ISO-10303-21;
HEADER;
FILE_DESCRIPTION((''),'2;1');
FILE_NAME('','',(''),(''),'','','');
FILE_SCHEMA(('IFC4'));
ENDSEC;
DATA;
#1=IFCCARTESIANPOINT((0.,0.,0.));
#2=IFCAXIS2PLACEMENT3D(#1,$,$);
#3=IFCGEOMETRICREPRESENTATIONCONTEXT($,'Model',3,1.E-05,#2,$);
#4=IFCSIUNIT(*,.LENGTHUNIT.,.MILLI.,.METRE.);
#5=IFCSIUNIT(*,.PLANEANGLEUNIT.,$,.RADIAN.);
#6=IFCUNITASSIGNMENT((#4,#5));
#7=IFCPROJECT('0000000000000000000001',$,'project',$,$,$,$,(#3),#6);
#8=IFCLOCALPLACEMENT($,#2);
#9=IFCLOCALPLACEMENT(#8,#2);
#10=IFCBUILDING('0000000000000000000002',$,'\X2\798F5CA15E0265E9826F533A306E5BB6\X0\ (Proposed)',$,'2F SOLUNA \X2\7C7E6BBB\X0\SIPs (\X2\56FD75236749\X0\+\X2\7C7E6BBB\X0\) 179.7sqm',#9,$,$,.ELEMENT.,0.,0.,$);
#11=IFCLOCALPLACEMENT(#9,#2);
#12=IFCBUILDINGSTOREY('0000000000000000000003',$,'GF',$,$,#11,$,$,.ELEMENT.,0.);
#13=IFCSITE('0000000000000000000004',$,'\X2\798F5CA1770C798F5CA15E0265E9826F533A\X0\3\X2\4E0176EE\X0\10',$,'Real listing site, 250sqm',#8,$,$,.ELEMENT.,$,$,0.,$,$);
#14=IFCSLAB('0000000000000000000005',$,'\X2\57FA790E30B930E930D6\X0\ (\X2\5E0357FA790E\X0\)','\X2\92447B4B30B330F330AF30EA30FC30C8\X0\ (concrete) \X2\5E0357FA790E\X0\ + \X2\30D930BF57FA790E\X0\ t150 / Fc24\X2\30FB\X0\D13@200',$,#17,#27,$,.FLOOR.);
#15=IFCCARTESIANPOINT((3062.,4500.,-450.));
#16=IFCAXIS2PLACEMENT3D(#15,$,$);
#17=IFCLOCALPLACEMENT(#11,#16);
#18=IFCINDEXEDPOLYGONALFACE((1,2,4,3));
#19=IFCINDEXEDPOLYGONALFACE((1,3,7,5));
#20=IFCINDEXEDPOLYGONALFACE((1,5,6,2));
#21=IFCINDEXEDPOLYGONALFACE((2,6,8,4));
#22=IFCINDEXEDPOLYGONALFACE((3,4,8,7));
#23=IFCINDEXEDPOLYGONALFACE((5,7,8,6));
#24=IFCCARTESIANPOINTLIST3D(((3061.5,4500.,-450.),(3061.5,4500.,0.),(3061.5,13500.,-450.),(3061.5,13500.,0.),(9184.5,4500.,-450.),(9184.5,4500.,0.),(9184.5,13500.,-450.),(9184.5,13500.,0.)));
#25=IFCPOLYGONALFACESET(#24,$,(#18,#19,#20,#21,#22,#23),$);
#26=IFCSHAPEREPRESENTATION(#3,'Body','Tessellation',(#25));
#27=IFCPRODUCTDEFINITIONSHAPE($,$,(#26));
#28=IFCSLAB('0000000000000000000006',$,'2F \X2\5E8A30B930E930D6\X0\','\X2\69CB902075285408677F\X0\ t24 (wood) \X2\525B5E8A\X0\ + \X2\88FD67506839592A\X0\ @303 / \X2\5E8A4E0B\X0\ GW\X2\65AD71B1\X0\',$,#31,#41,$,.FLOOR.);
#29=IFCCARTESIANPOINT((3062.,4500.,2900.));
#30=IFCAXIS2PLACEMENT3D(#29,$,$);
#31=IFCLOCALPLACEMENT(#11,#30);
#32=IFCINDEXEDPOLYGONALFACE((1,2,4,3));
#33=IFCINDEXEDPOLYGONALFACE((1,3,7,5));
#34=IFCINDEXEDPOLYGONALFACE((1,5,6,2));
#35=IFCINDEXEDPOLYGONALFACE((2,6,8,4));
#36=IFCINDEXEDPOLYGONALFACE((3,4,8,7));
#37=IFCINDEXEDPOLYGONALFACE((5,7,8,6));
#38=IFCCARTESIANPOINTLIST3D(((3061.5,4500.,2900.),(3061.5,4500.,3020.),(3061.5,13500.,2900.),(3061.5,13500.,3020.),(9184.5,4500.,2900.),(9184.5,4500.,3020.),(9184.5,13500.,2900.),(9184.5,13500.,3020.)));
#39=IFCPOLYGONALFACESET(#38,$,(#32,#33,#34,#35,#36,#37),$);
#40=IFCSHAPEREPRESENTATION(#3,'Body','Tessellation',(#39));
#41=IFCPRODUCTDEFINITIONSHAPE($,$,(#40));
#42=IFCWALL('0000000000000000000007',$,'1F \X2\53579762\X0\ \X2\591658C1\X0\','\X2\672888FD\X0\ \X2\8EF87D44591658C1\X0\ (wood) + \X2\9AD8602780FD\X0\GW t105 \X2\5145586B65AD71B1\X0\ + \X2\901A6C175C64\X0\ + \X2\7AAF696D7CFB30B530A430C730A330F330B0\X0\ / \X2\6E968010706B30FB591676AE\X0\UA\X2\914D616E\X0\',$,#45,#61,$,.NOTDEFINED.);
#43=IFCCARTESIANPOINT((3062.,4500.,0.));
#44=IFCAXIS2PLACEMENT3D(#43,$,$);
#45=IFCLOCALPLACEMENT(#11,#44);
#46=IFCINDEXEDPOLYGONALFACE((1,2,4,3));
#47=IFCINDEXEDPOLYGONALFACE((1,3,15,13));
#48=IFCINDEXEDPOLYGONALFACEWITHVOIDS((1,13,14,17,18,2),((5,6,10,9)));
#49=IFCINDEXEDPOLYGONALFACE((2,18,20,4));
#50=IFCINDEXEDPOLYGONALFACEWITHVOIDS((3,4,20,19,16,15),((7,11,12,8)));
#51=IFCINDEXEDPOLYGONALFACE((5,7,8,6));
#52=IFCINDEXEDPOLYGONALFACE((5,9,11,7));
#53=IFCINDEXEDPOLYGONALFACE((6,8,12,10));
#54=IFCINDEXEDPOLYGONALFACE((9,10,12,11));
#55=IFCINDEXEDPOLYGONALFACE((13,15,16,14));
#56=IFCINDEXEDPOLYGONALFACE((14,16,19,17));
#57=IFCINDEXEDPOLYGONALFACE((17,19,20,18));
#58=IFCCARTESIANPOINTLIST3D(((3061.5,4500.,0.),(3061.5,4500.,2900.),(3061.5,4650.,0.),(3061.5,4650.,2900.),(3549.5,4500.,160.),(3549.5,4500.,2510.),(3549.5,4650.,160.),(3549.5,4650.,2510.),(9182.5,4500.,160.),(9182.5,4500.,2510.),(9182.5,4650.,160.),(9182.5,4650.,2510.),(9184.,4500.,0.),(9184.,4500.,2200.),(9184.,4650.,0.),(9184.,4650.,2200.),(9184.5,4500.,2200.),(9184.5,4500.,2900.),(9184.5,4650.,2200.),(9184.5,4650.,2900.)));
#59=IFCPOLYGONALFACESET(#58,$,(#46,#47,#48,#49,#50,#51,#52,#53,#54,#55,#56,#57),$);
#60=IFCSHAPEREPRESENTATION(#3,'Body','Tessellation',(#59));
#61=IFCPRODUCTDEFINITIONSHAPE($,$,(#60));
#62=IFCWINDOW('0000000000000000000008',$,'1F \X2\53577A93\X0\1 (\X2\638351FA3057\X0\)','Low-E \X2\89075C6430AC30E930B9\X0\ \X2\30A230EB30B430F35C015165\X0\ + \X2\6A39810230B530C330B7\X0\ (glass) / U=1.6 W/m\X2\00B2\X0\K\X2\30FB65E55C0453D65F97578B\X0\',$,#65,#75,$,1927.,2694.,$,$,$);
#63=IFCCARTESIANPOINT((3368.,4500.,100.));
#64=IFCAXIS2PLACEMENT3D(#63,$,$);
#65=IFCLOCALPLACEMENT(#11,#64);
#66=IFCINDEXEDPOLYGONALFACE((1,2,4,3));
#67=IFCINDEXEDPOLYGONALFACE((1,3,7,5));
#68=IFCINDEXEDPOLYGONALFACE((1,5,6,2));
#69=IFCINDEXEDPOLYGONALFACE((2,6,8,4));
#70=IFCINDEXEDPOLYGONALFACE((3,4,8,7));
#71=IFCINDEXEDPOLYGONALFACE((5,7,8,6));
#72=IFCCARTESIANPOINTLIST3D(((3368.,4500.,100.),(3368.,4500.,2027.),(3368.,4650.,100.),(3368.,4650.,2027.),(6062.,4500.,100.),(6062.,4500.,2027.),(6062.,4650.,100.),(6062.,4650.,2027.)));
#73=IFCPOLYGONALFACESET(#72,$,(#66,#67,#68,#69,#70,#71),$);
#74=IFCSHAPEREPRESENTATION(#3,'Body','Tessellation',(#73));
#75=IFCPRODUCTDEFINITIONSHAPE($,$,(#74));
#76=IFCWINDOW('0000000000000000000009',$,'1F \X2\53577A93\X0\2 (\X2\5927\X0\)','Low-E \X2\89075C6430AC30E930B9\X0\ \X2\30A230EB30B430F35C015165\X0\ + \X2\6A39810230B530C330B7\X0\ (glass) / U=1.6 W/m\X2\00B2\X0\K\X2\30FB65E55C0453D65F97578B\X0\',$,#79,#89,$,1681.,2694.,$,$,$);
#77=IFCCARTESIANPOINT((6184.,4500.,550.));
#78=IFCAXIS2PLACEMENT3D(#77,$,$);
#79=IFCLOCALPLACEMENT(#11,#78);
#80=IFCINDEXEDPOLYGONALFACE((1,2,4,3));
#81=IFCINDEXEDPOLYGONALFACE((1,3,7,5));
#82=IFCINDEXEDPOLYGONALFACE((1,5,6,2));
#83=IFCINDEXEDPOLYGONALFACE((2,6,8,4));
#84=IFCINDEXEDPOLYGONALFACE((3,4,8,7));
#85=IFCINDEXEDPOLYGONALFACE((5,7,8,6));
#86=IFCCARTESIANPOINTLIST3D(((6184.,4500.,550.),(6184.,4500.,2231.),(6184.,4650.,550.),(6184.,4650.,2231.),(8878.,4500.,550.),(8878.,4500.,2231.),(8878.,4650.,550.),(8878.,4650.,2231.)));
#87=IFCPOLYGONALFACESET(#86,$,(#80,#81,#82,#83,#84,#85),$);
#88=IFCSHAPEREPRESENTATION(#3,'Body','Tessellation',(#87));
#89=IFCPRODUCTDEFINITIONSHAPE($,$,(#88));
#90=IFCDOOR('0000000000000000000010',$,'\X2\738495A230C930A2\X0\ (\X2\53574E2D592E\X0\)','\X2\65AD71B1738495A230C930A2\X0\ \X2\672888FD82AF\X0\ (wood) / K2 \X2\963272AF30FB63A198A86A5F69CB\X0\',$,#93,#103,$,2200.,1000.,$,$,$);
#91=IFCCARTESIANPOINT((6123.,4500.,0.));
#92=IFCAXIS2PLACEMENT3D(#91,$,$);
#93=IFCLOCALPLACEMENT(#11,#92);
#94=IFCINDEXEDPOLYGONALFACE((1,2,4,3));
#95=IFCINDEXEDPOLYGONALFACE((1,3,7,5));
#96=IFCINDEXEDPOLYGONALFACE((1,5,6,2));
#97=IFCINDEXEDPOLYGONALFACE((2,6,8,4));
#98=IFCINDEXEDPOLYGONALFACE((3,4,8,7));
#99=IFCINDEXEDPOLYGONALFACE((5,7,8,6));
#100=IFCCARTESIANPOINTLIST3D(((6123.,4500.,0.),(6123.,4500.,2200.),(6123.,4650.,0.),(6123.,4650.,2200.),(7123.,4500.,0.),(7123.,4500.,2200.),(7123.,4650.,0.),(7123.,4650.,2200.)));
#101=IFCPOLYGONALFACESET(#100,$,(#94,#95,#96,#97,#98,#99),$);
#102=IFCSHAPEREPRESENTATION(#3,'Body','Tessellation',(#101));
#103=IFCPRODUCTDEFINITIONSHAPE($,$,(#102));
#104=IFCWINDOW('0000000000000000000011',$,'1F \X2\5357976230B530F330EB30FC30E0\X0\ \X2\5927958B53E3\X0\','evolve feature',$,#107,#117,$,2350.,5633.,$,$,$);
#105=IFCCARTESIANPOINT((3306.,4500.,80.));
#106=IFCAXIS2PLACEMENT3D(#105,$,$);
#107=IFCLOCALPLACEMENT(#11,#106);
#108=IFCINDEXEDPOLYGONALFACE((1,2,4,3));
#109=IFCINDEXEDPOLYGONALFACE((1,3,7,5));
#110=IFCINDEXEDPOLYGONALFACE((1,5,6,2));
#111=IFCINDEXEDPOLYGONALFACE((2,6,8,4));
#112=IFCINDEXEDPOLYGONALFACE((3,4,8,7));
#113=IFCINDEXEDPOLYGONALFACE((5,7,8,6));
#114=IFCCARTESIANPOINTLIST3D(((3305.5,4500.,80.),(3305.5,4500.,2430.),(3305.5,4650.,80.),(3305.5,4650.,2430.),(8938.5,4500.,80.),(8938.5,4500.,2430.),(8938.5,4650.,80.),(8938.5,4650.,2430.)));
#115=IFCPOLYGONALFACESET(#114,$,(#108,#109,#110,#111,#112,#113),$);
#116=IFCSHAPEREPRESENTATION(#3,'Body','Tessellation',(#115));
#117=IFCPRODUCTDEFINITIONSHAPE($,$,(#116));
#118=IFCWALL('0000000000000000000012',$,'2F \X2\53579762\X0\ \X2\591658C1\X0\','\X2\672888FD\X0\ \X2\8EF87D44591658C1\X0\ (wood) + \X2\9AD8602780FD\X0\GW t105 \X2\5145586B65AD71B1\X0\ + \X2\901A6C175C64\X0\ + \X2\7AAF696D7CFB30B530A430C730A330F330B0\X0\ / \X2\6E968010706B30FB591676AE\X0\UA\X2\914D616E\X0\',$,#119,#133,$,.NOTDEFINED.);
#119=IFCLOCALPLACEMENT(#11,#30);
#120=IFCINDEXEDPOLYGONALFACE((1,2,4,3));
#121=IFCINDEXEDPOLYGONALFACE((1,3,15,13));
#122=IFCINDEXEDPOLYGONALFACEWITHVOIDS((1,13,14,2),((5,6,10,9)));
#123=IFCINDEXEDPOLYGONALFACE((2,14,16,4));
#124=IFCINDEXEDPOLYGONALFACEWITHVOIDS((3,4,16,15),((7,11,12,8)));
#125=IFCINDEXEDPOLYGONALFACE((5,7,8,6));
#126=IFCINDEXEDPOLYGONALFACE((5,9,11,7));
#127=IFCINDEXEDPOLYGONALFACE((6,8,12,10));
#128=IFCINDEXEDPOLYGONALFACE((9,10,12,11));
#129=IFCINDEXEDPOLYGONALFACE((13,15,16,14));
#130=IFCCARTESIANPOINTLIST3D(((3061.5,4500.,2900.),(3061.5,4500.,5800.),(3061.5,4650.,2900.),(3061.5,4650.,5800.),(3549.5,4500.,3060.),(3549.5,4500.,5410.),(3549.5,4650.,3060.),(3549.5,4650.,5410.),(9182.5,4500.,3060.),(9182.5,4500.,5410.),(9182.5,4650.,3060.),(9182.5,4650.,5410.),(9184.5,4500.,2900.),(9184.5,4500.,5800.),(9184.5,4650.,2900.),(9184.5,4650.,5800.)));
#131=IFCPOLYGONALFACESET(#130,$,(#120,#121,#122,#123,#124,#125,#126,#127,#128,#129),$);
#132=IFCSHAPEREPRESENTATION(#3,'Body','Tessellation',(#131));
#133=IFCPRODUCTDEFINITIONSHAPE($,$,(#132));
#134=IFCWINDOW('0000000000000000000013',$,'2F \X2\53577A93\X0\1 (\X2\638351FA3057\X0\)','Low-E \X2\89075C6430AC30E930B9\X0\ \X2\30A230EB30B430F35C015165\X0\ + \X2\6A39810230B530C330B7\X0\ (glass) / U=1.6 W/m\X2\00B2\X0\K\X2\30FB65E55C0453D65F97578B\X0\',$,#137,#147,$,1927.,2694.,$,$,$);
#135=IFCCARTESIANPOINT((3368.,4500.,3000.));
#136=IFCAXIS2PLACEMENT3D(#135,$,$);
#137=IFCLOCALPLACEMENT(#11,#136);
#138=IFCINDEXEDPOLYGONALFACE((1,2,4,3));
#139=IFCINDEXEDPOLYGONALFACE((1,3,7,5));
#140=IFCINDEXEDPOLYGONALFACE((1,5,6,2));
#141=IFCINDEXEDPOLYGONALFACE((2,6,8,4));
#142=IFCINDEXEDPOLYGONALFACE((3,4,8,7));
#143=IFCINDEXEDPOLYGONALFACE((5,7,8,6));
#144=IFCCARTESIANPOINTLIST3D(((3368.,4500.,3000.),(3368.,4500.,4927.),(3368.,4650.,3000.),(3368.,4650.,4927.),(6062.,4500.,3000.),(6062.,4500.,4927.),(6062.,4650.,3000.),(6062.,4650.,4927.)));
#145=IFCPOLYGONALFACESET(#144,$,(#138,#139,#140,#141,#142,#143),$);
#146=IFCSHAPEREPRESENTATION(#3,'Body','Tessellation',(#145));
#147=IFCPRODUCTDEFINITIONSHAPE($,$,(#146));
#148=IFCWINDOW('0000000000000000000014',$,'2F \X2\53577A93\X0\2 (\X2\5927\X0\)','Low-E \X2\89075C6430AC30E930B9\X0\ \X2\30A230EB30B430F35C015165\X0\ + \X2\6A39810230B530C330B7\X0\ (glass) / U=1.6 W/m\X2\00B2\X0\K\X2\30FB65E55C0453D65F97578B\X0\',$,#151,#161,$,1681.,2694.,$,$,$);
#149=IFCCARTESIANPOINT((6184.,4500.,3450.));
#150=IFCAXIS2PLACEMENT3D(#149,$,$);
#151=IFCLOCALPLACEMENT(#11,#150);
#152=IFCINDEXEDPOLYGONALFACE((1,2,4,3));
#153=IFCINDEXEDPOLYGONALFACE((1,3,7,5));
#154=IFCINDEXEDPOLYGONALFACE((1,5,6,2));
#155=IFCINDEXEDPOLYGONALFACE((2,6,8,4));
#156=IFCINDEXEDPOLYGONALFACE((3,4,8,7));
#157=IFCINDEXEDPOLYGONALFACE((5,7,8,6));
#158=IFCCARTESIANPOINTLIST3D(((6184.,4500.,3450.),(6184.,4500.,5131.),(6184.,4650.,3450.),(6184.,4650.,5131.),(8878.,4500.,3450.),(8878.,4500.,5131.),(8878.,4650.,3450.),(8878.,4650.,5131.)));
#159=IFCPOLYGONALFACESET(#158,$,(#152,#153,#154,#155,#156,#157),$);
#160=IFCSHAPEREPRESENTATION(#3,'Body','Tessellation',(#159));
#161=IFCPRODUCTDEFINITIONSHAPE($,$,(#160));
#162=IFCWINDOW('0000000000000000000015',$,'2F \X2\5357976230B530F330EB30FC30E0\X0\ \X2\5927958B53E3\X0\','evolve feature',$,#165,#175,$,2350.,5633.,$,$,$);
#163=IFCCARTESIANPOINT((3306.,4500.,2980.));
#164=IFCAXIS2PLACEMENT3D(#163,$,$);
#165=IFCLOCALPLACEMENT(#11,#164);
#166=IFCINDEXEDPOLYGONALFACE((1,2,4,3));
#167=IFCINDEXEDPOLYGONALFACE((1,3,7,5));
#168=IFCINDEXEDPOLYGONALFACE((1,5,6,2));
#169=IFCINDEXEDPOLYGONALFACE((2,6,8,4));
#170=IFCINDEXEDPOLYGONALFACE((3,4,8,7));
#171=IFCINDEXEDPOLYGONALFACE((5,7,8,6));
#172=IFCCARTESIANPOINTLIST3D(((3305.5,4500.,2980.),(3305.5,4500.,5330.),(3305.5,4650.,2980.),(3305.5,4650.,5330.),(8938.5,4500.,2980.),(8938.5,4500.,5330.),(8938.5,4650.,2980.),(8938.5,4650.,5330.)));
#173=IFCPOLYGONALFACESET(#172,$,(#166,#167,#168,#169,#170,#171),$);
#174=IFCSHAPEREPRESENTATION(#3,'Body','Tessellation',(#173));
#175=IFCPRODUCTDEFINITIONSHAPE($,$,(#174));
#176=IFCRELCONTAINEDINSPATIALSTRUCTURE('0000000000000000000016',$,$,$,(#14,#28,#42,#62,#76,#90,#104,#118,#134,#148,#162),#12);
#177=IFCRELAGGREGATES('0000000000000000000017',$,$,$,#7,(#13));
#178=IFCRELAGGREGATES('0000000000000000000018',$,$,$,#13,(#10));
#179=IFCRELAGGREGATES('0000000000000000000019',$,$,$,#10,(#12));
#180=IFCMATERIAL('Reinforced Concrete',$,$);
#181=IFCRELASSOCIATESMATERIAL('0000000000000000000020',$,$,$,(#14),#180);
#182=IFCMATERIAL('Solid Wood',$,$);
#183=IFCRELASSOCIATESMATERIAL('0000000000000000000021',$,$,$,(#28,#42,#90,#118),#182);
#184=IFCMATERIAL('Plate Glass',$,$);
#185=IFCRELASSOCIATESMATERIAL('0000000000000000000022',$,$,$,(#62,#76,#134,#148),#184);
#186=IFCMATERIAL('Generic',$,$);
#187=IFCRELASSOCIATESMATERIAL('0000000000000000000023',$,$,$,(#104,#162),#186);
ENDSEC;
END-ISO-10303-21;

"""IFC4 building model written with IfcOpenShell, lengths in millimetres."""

from ifc_helpers import new_model, si_unit, frame, frame_2d, origin, place, context, project, spatial, rectangle, extrude, material, element, fill, save


model = new_model("IFC4")

# Units and contexts
model_context = context("Model", 3, precision=1e-05, world=origin())
ifc_project = project(units=[si_unit("LENGTHUNIT", "METRE", prefix="MILLI"), si_unit("PLANEANGLEUNIT", "RADIAN")], contexts=[model_context])

# Site, building, storey
site_placement = place(None, origin())
site = spatial("IfcSite", under=ifc_project, at=site_placement, Name="福岡県福岡市早良区3丁目10", ObjectType="Real listing site, 250sqm", CompositionType="ELEMENT", RefElevation=0.0)
building_placement = place(site_placement, origin())
building = spatial("IfcBuilding", under=site, at=building_placement, Name="福岡市早良区の家 (Proposed)", ObjectType="2F SOLUNA 籾殻SIPs (国産杉+籾殻) 179.7sqm", CompositionType="ELEMENT", ElevationOfRefHeight=0.0, ElevationOfTerrain=0.0)
storey_placement = place(building_placement, origin())
storey = spatial("IfcBuildingStorey", under=building, at=storey_placement, Name="GF", CompositionType="ELEMENT", Elevation=0.0)

# Slabs
ifc_material_1 = material(Name="Reinforced Concrete")
slab_1_placement = place(storey_placement, frame((3062.0, 4500.0, -450.0)))
element("IfcSlab", 1, at=slab_1_placement, inside=storey, material=ifc_material_1, Name="基礎スラブ (布基礎)", Description="鉄筋コンクリート (concrete) 布基礎 + ベタ基礎 t150 / Fc24・D13@200", PredefinedType="FLOOR", context=model_context, shape_type="SweptSolid", body=[
    extrude(rectangle(XDim=6123.0, YDim=9000.0, at=frame_2d((3061.0, 4500.0))), frame((3062.0, 4500.0, -450.0)), (0.0, 0.0, 1.0), 450.0),
])
ifc_material_2 = material(Name="Solid Wood")
slab_2_placement = place(storey_placement, frame((3062.0, 4500.0, 2900.0)))
element("IfcSlab", 2, at=slab_2_placement, inside=storey, material=ifc_material_2, Name="2F 床スラブ", Description="構造用合板 t24 (wood) 剛床 + 製材根太 @303 / 床下 GW断熱", PredefinedType="FLOOR", context=model_context, shape_type="SweptSolid", body=[
    extrude(rectangle(XDim=6123.0, YDim=9000.0, at=frame_2d((3061.0, 4500.0))), frame((3062.0, 4500.0, 2900.0)), (0.0, 0.0, 1.0), 120.0),
])
ifc_material_3 = material(Name="Generic")

# Wall, openings, windows, door
wall_1_placement = place(storey_placement, frame((3062.0, 4500.0, 0.0)))
wall_1 = element("IfcWall", 3, at=wall_1_placement, inside=storey, material=ifc_material_2, Name="1F 南面 外壁", Description="木製 軸組外壁 (wood) + 高性能GW t105 充填断熱 + 通気層 + 窯業系サイディング / 準耐火・外皮UA配慮", PredefinedType="NOTDEFINED", context=model_context, shape_type="SweptSolid", body=[
    extrude(rectangle(XDim=6123.0, YDim=150.0, at=frame_2d((3061.0, 75.0))), frame((3062.0, 4500.0, 0.0)), (0.0, 0.0, 1.0), 2900.0),
])
opening_1_placement = place(storey_placement, frame((3368.0, 4500.0, 100.0)))
opening_1 = element("IfcOpeningElement", 4, at=opening_1_placement, cuts=wall_1, PredefinedType="NOTDEFINED", context=model_context, shape_type="SweptSolid", body=[
    extrude(rectangle(XDim=2694.0, YDim=150.0, at=frame_2d((1347.0, 75.0))), frame((3368.0, 4500.0, 100.0)), (0.0, 0.0, 1.0), 1927.0),
])
opening_2_placement = place(storey_placement, frame((6184.0, 4500.0, 550.0)))
opening_2 = element("IfcOpeningElement", 5, at=opening_2_placement, cuts=wall_1, PredefinedType="NOTDEFINED", context=model_context, shape_type="SweptSolid", body=[
    extrude(rectangle(XDim=2694.0, YDim=150.0, at=frame_2d((1347.0, 75.0))), frame((6184.0, 4500.0, 550.0)), (0.0, 0.0, 1.0), 1681.0),
])
opening_3_placement = place(storey_placement, frame((6123.0, 4500.0, 0.0)))
opening_3 = element("IfcOpeningElement", 6, at=opening_3_placement, cuts=wall_1, PredefinedType="NOTDEFINED", context=model_context, shape_type="SweptSolid", body=[
    extrude(rectangle(XDim=1000.0, YDim=150.0, at=frame_2d((500.0, 75.0))), frame((6123.0, 4500.0, 0.0)), (0.0, 0.0, 1.0), 2200.0),
])
opening_4_placement = place(storey_placement, frame((3306.0, 4500.0, 80.0)))
opening_4 = element("IfcOpeningElement", 7, at=opening_4_placement, cuts=wall_1, PredefinedType="NOTDEFINED", context=model_context, shape_type="SweptSolid", body=[
    extrude(rectangle(XDim=5633.0, YDim=150.0, at=frame_2d((2816.0, 75.0))), frame((3306.0, 4500.0, 80.0)), (0.0, 0.0, 1.0), 2350.0),
])
ifc_material_4 = material(Name="Plate Glass")
window_1_placement = place(storey_placement, frame((3368.0, 4500.0, 100.0)))
window_1 = element("IfcWindow", 8, at=window_1_placement, inside=storey, material=ifc_material_4, Name="1F 南窓1 (掃出し)", Description="Low-E 複層ガラス アルゴン封入 + 樹脂サッシ (glass) / U=1.6 W/m²K・日射取得型", OverallHeight=1927.0, OverallWidth=2694.0, context=model_context, shape_type="SweptSolid", body=[
    extrude(rectangle(XDim=2694.0, YDim=150.0, at=frame_2d((1347.0, 75.0))), frame((3368.0, 4500.0, 100.0)), (0.0, 0.0, 1.0), 1927.0),
])
fill(opening_1, window_1)
window_2_placement = place(storey_placement, frame((6184.0, 4500.0, 550.0)))
window_2 = element("IfcWindow", 9, at=window_2_placement, inside=storey, material=ifc_material_4, Name="1F 南窓2 (大)", Description="Low-E 複層ガラス アルゴン封入 + 樹脂サッシ (glass) / U=1.6 W/m²K・日射取得型", OverallHeight=1681.0, OverallWidth=2694.0, context=model_context, shape_type="SweptSolid", body=[
    extrude(rectangle(XDim=2694.0, YDim=150.0, at=frame_2d((1347.0, 75.0))), frame((6184.0, 4500.0, 550.0)), (0.0, 0.0, 1.0), 1681.0),
])
fill(opening_2, window_2)
door_placement = place(storey_placement, frame((6123.0, 4500.0, 0.0)))
door = element("IfcDoor", 10, at=door_placement, inside=storey, material=ifc_material_2, Name="玄関ドア (南中央)", Description="断熱玄関ドア 木製芯 (wood) / K2 防犯・採風機構", OverallHeight=2200.0, OverallWidth=1000.0, context=model_context, shape_type="SweptSolid", body=[
    extrude(rectangle(XDim=1000.0, YDim=150.0, at=frame_2d((500.0, 75.0))), frame((6123.0, 4500.0, 0.0)), (0.0, 0.0, 1.0), 2200.0),
])
fill(opening_3, door)
window_3_placement = place(storey_placement, frame((3306.0, 4500.0, 80.0)))
window_3 = element("IfcWindow", 11, at=window_3_placement, inside=storey, material=ifc_material_3, Name="1F 南面サンルーム 大開口", Description="evolve feature", OverallHeight=2350.0, OverallWidth=5633.0, context=model_context, shape_type="SweptSolid", body=[
    extrude(rectangle(XDim=5633.0, YDim=150.0, at=frame_2d((2816.0, 75.0))), frame((3306.0, 4500.0, 80.0)), (0.0, 0.0, 1.0), 2350.0),
])
fill(opening_4, window_3)

# Wall, openings, windows
wall_2_placement = place(storey_placement, frame((3062.0, 4500.0, 2900.0)))
wall_2 = element("IfcWall", 12, at=wall_2_placement, inside=storey, material=ifc_material_2, Name="2F 南面 外壁", Description="木製 軸組外壁 (wood) + 高性能GW t105 充填断熱 + 通気層 + 窯業系サイディング / 準耐火・外皮UA配慮", PredefinedType="NOTDEFINED", context=model_context, shape_type="SweptSolid", body=[
    extrude(rectangle(XDim=6123.0, YDim=150.0, at=frame_2d((3061.0, 75.0))), frame((3062.0, 4500.0, 2900.0)), (0.0, 0.0, 1.0), 2900.0),
])
opening_5_placement = place(storey_placement, frame((3368.0, 4500.0, 3000.0)))
opening_5 = element("IfcOpeningElement", 13, at=opening_5_placement, cuts=wall_2, PredefinedType="NOTDEFINED", context=model_context, shape_type="SweptSolid", body=[
    extrude(rectangle(XDim=2694.0, YDim=150.0, at=frame_2d((1347.0, 75.0))), frame((3368.0, 4500.0, 3000.0)), (0.0, 0.0, 1.0), 1927.0),
])
opening_6_placement = place(storey_placement, frame((6184.0, 4500.0, 3450.0)))
opening_6 = element("IfcOpeningElement", 14, at=opening_6_placement, cuts=wall_2, PredefinedType="NOTDEFINED", context=model_context, shape_type="SweptSolid", body=[
    extrude(rectangle(XDim=2694.0, YDim=150.0, at=frame_2d((1347.0, 75.0))), frame((6184.0, 4500.0, 3450.0)), (0.0, 0.0, 1.0), 1681.0),
])
opening_7_placement = place(storey_placement, frame((3306.0, 4500.0, 2980.0)))
opening_7 = element("IfcOpeningElement", 15, at=opening_7_placement, cuts=wall_2, PredefinedType="NOTDEFINED", context=model_context, shape_type="SweptSolid", body=[
    extrude(rectangle(XDim=5633.0, YDim=150.0, at=frame_2d((2816.0, 75.0))), frame((3306.0, 4500.0, 2980.0)), (0.0, 0.0, 1.0), 2350.0),
])
window_4_placement = place(storey_placement, frame((3368.0, 4500.0, 3000.0)))
window_4 = element("IfcWindow", 16, at=window_4_placement, inside=storey, material=ifc_material_4, Name="2F 南窓1 (掃出し)", Description="Low-E 複層ガラス アルゴン封入 + 樹脂サッシ (glass) / U=1.6 W/m²K・日射取得型", OverallHeight=1927.0, OverallWidth=2694.0, context=model_context, shape_type="SweptSolid", body=[
    extrude(rectangle(XDim=2694.0, YDim=150.0, at=frame_2d((1347.0, 75.0))), frame((3368.0, 4500.0, 3000.0)), (0.0, 0.0, 1.0), 1927.0),
])
fill(opening_5, window_4)
window_5_placement = place(storey_placement, frame((6184.0, 4500.0, 3450.0)))
window_5 = element("IfcWindow", 17, at=window_5_placement, inside=storey, material=ifc_material_4, Name="2F 南窓2 (大)", Description="Low-E 複層ガラス アルゴン封入 + 樹脂サッシ (glass) / U=1.6 W/m²K・日射取得型", OverallHeight=1681.0, OverallWidth=2694.0, context=model_context, shape_type="SweptSolid", body=[
    extrude(rectangle(XDim=2694.0, YDim=150.0, at=frame_2d((1347.0, 75.0))), frame((6184.0, 4500.0, 3450.0)), (0.0, 0.0, 1.0), 1681.0),
])
fill(opening_6, window_5)
window_6_placement = place(storey_placement, frame((3306.0, 4500.0, 2980.0)))
window_6 = element("IfcWindow", 18, at=window_6_placement, inside=storey, material=ifc_material_3, Name="2F 南面サンルーム 大開口", Description="evolve feature", OverallHeight=2350.0, OverallWidth=5633.0, context=model_context, shape_type="SweptSolid", body=[
    extrude(rectangle(XDim=5633.0, YDim=150.0, at=frame_2d((2816.0, 75.0))), frame((3306.0, 4500.0, 2980.0)), (0.0, 0.0, 1.0), 2350.0),
])
fill(opening_7, window_6)

save(model, "model.ifc")
